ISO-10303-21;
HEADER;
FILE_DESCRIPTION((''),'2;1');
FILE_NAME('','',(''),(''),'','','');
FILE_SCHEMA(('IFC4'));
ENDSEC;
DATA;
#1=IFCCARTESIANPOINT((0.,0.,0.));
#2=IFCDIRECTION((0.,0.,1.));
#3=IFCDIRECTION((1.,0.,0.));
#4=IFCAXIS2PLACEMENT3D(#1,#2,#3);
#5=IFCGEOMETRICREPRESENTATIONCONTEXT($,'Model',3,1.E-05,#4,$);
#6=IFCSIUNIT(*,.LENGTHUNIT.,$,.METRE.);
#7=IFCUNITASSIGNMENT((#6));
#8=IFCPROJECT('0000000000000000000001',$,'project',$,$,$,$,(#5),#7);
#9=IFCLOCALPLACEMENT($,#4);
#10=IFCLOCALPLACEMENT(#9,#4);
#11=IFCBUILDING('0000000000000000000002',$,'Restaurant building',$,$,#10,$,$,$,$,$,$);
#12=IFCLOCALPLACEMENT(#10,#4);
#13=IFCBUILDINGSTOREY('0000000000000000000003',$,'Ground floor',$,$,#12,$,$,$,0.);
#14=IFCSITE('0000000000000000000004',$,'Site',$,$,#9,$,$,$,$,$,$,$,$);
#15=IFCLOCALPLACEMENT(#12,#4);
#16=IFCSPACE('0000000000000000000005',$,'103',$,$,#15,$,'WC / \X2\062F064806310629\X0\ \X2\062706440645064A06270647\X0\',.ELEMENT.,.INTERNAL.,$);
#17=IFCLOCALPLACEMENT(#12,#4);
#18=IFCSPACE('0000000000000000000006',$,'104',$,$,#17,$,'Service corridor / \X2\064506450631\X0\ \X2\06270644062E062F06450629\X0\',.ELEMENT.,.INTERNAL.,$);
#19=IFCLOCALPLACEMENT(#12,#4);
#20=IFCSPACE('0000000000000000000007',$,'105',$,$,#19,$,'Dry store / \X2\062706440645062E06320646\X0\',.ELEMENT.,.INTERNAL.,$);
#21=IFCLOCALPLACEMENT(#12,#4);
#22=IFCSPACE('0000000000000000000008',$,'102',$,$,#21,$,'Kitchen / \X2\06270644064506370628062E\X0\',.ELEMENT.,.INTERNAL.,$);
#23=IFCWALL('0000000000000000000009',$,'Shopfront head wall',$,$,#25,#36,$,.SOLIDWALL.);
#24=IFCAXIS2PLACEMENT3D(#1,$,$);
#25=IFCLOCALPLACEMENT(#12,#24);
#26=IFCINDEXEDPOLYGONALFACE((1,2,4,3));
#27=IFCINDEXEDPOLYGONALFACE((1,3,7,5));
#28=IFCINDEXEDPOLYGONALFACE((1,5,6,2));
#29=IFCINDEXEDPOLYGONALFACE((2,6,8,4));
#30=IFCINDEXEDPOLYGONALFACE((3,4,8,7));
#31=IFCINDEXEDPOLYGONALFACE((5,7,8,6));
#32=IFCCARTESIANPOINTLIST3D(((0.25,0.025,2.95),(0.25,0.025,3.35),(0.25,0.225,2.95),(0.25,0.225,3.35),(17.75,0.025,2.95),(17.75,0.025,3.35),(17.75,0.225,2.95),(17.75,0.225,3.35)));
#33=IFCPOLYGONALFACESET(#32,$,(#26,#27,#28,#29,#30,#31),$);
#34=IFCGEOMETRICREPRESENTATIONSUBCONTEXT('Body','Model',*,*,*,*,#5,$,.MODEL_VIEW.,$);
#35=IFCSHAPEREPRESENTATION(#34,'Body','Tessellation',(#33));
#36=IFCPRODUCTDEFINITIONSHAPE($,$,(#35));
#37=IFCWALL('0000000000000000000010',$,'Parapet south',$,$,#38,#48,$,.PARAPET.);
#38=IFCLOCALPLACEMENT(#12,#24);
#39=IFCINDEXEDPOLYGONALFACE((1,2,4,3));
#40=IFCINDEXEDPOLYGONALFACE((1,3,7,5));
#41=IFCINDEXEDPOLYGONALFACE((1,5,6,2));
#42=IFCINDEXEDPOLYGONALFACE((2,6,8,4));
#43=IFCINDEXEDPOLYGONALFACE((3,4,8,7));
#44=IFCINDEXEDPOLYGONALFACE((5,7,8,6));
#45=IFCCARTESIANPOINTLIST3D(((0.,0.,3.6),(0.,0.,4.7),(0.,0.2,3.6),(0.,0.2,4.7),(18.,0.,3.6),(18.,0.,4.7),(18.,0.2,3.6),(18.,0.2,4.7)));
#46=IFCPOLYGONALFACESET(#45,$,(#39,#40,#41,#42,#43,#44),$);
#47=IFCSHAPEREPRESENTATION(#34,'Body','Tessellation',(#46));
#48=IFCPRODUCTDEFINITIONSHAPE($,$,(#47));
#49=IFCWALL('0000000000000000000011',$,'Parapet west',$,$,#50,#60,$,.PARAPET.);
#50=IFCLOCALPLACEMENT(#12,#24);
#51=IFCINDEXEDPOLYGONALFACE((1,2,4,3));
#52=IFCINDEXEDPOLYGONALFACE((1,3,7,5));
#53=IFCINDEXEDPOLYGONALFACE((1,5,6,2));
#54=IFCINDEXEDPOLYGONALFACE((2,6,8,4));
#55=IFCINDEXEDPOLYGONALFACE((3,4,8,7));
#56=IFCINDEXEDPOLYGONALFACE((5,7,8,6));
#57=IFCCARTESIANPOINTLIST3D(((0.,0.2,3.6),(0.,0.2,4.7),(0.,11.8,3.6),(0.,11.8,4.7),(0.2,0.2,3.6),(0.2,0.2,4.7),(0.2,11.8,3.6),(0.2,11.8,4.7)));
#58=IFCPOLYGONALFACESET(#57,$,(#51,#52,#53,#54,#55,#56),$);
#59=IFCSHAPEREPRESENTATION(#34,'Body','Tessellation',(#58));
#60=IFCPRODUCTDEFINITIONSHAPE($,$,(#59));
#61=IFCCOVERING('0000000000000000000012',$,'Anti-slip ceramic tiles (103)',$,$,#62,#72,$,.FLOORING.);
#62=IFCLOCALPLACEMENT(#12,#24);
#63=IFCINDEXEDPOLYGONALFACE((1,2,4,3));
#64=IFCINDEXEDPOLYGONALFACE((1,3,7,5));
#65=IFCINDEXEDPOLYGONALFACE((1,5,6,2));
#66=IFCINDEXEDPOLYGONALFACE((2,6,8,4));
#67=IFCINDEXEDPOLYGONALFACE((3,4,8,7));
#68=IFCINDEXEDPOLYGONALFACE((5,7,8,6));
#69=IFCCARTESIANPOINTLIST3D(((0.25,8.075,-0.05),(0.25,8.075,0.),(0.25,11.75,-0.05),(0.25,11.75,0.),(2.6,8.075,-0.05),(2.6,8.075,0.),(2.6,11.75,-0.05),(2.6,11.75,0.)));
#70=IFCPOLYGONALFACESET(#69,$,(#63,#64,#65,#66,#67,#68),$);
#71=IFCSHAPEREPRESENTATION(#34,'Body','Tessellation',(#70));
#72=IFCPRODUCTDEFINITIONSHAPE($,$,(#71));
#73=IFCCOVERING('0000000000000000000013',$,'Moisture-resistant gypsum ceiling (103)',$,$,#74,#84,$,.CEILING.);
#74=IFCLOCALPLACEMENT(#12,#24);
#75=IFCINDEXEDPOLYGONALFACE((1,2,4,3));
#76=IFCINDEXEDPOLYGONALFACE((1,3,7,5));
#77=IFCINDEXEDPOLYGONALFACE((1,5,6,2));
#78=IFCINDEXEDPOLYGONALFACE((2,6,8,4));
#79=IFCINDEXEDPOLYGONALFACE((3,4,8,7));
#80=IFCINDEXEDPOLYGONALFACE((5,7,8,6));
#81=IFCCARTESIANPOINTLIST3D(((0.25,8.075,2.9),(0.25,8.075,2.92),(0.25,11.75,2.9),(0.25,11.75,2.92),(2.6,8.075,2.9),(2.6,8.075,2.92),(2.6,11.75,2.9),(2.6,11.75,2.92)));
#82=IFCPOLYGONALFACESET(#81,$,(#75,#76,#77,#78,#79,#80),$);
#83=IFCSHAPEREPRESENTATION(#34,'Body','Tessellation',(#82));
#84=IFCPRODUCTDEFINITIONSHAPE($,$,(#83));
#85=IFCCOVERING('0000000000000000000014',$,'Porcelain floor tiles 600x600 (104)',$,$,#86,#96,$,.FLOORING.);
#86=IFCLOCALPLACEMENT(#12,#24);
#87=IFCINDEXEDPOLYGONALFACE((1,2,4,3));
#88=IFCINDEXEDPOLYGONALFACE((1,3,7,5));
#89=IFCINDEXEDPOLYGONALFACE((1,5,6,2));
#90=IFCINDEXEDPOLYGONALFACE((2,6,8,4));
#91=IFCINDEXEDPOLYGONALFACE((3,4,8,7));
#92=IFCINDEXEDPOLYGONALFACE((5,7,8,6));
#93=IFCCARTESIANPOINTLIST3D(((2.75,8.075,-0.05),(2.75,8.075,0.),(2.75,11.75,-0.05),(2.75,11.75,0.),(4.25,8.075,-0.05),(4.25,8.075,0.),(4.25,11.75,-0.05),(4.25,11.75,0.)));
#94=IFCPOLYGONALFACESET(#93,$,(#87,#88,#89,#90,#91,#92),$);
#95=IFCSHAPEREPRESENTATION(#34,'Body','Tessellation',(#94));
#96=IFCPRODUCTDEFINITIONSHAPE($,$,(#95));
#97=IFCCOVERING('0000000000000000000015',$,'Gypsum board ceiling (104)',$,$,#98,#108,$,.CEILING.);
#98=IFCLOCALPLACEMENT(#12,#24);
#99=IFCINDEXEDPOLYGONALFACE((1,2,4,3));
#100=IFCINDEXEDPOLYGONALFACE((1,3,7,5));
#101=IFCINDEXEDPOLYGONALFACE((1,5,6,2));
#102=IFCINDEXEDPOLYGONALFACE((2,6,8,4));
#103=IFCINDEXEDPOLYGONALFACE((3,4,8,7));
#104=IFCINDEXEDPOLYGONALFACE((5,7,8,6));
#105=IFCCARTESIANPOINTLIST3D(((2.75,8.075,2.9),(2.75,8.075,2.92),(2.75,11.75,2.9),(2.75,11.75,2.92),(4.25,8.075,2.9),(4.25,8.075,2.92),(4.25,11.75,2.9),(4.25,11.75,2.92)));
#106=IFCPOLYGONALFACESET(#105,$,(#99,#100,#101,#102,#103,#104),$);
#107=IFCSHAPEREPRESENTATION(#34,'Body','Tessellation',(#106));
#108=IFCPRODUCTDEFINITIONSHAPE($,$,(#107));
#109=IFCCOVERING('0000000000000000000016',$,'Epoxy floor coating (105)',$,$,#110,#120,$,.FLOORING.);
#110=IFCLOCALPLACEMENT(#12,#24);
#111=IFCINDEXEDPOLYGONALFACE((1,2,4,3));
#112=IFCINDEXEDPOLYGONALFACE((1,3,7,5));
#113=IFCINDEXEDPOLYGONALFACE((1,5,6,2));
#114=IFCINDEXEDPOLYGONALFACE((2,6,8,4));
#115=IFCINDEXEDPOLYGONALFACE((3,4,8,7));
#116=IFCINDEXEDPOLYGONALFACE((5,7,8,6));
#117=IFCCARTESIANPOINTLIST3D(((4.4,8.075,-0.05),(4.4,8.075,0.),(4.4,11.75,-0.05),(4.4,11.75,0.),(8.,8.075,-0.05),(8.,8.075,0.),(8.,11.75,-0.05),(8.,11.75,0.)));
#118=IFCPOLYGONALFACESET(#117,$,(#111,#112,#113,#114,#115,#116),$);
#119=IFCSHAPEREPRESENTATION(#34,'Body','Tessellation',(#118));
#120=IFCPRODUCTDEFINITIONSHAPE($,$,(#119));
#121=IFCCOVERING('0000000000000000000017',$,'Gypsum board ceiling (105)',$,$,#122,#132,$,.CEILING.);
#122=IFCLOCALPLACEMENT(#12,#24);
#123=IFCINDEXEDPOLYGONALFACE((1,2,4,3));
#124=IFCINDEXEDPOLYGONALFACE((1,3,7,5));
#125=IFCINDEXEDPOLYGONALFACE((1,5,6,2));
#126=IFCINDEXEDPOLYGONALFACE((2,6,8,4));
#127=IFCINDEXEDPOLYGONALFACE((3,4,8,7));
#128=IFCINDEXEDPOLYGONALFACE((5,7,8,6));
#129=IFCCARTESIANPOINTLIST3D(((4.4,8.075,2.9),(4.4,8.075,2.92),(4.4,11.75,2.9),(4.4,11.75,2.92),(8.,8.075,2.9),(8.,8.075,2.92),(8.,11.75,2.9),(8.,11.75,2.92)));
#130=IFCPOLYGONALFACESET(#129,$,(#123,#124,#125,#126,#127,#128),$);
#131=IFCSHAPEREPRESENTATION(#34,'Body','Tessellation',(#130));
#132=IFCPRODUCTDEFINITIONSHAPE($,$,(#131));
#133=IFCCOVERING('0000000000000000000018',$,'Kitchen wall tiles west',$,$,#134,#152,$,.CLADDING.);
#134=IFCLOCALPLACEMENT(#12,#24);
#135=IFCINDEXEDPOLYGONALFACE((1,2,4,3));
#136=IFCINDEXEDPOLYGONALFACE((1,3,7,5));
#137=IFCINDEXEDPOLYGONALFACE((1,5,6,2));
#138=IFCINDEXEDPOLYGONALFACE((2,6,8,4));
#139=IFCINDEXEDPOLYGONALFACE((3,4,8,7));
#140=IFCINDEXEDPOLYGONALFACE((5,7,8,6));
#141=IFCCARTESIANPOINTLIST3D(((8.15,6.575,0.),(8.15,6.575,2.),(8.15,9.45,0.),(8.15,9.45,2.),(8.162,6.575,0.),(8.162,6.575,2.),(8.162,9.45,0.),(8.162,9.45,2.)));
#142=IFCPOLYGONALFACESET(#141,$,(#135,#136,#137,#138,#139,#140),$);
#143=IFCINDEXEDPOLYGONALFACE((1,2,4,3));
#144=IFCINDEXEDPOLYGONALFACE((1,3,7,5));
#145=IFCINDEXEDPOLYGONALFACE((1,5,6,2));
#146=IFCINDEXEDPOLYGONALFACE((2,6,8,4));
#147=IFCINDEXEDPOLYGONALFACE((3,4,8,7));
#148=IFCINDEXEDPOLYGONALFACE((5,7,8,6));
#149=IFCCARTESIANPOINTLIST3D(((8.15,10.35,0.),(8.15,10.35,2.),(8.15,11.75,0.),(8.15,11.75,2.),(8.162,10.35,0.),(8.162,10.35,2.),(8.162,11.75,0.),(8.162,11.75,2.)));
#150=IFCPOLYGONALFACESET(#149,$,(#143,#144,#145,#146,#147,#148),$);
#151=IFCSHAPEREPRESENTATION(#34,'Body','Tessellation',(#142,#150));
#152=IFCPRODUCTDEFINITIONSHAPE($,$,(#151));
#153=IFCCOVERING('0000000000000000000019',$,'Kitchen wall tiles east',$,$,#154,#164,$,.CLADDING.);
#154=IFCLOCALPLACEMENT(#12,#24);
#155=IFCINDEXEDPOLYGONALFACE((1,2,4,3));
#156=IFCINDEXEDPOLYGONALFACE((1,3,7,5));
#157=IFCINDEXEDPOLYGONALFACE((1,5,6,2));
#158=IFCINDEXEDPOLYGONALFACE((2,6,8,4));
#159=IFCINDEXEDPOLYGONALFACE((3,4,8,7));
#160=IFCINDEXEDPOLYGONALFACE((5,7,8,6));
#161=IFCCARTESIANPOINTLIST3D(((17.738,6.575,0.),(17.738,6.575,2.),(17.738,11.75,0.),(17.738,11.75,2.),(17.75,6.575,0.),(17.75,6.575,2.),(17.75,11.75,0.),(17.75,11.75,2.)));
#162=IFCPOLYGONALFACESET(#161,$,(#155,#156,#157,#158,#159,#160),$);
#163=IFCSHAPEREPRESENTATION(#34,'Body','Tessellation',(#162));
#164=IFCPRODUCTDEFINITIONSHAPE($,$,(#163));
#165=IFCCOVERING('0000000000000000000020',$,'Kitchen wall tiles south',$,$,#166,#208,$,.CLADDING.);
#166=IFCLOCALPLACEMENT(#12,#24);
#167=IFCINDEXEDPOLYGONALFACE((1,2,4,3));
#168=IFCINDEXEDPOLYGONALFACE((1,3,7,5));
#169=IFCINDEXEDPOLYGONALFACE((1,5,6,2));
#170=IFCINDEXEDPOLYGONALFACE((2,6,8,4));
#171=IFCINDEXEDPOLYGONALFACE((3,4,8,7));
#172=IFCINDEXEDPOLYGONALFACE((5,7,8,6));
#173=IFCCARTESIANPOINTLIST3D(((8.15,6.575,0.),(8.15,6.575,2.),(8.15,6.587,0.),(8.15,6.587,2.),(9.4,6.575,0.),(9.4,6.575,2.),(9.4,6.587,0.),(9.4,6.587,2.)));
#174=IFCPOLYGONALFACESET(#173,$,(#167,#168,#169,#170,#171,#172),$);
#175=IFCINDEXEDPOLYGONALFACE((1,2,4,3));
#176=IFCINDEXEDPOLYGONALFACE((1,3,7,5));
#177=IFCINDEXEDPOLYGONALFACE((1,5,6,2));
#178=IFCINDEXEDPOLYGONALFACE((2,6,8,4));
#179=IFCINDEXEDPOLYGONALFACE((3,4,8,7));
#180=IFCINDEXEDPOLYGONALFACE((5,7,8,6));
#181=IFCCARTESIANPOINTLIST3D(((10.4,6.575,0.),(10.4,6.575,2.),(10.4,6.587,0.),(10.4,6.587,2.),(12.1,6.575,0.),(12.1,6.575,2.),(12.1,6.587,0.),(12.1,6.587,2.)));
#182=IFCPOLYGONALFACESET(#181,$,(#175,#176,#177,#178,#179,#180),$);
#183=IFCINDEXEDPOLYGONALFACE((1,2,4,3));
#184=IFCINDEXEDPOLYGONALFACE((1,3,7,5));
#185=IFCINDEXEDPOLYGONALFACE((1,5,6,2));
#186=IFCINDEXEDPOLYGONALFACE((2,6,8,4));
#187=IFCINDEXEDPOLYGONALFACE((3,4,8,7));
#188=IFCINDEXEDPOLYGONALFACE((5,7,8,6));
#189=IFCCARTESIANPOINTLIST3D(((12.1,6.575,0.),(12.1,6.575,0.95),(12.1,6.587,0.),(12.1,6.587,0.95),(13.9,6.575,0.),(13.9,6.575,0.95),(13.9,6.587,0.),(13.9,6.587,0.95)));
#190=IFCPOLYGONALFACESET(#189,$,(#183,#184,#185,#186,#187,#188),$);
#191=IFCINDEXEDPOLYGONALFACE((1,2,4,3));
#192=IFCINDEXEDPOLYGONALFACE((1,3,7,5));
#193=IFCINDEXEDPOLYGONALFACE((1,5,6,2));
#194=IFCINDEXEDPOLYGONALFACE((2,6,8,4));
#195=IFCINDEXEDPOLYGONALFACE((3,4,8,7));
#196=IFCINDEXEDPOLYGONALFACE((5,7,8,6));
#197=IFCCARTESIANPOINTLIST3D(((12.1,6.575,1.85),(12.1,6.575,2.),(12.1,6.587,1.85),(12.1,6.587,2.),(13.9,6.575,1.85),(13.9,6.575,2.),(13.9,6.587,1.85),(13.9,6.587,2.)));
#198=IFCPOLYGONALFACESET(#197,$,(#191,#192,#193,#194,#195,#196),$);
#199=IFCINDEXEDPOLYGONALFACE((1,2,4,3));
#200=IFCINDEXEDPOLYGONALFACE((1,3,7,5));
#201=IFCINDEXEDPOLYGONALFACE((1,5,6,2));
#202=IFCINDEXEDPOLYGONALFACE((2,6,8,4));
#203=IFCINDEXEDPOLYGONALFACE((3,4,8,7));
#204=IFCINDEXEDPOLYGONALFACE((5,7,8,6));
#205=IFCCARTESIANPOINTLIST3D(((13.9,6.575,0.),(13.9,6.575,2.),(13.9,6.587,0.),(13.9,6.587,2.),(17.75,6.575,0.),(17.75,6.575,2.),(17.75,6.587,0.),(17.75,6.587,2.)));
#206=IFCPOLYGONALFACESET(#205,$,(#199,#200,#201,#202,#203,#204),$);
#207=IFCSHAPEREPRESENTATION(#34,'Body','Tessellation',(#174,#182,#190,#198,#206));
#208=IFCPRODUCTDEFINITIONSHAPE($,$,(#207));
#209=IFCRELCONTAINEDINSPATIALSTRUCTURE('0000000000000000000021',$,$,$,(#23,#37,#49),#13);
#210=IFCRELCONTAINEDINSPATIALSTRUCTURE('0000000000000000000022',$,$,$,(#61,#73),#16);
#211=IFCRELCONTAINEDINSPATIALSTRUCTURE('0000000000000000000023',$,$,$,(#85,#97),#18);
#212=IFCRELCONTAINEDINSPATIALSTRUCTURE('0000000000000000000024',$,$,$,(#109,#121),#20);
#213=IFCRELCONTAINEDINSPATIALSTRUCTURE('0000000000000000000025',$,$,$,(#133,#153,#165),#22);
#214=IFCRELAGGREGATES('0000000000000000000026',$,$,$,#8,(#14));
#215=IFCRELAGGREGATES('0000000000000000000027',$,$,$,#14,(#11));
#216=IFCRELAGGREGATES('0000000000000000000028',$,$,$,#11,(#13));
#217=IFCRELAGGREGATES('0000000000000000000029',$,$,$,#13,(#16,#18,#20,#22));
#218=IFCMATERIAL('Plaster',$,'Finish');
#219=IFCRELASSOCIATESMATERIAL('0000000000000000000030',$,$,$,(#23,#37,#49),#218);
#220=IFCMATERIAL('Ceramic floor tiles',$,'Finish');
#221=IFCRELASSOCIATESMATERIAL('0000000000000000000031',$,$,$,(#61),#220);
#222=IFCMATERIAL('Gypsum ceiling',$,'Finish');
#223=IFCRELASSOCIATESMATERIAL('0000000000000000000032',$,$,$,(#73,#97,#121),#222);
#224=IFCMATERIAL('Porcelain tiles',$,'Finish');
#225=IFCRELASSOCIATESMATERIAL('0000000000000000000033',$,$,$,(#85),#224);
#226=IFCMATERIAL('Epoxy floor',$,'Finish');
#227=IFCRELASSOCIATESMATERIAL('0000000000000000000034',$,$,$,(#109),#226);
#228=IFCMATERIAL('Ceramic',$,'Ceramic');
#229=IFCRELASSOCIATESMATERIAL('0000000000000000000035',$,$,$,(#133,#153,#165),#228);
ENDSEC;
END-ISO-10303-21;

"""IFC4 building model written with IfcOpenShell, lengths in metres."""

from ifc_helpers import new_model, si_unit, frame, origin, origin_with_axes, origin_2d, place, context, subcontext, project, spatial, polyline, rectangle, outline, extrude, material, element, save


model = new_model("IFC4")

# Units and contexts
model_context = context("Model", 3, precision=1e-05, world=origin_with_axes())
body_context = subcontext(model_context, "Body", "Model", "MODEL_VIEW")
ifc_project = project(units=[si_unit("LENGTHUNIT", "METRE")], contexts=[model_context])

# Site, building, storey
site_placement = place(None, origin_with_axes())
site = spatial("IfcSite", under=ifc_project, at=site_placement, Name="Site")
building_placement = place(site_placement, origin_with_axes())
building = spatial("IfcBuilding", under=site, at=building_placement, Name="Restaurant building")
storey_placement = place(building_placement, origin_with_axes())
storey = spatial("IfcBuildingStorey", under=building, at=storey_placement, Name="Ground floor", Elevation=0.0)

# Shared definitions
ifc_material_1 = material(Name="Plaster", Category="Finish")

# Walls
wall_1_placement = place(storey_placement, frame((0.25, 0.125, 0.0)))
element("IfcWall", 1, at=wall_1_placement, inside=storey, material=ifc_material_1, Name="Shopfront head wall", PredefinedType="SOLIDWALL", context=body_context, shape_type="SweptSolid", body=[
    extrude(rectangle(XDim=17.5, YDim=0.2, at=origin_2d()), frame((8.75, 0.0, 2.95)), (0.0, 0.0, 1.0), 0.4),
])
wall_2_placement = place(storey_placement, frame((0.0, 0.1, 0.0)))
element("IfcWall", 2, at=wall_2_placement, inside=storey, material=ifc_material_1, Name="Parapet south", PredefinedType="PARAPET", context=body_context, shape_type="SweptSolid", body=[
    extrude(rectangle(XDim=18.0, YDim=0.2, at=origin_2d()), frame((9.0, 0.0, 3.6)), (0.0, 0.0, 1.0), 1.1),
])
wall_3_placement = place(storey_placement, frame((0.1, 0.2, 0.0), z_axis=(0.0, 0.0, 1.0), x_axis=(0.0, 1.0, 0.0)))
element("IfcWall", 3, at=wall_3_placement, inside=storey, material=ifc_material_1, Name="Parapet west", PredefinedType="PARAPET", context=body_context, shape_type="SweptSolid", body=[
    extrude(rectangle(XDim=11.6, YDim=0.2, at=origin_2d()), frame((5.8, 0.0, 3.6)), (0.0, 0.0, 1.0), 1.1),
])

# Shared definitions
space_1_placement = place(storey_placement, origin_with_axes())
space_1 = spatial("IfcSpace", under=storey, at=space_1_placement, Name="103", LongName="WC / دورة المياه", CompositionType="ELEMENT", PredefinedType="INTERNAL")

# Coverings
ifc_material_2 = material(Name="Ceramic floor tiles", Category="Finish")
covering_1_placement = place(storey_placement, origin())
element("IfcCovering", 4, at=covering_1_placement, inside=space_1, material=ifc_material_2, Name="Anti-slip ceramic tiles (103)", PredefinedType="FLOORING", context=body_context, shape_type="SweptSolid", body=[
    extrude(outline(polyline([(0.25, 8.075), (2.6, 8.075), (2.6, 11.75), (0.25, 11.75), (0.25, 8.075)])), frame((0.0, 0.0, -0.05)), (0.0, 0.0, 1.0), 0.05),
])
ifc_material_3 = material(Name="Gypsum ceiling", Category="Finish")
covering_2_placement = place(storey_placement, origin())
element("IfcCovering", 5, at=covering_2_placement, inside=space_1, material=ifc_material_3, Name="Moisture-resistant gypsum ceiling (103)", PredefinedType="CEILING", context=body_context, shape_type="SweptSolid", body=[
    extrude(outline(polyline([(0.25, 8.075), (2.6, 8.075), (2.6, 11.75), (0.25, 11.75), (0.25, 8.075)])), frame((0.0, 0.0, 2.9)), (0.0, 0.0, 1.0), 0.02),
])

# Shared definitions
space_2_placement = place(storey_placement, origin_with_axes())
space_2 = spatial("IfcSpace", under=storey, at=space_2_placement, Name="104", LongName="Service corridor / ممر الخدمة", CompositionType="ELEMENT", PredefinedType="INTERNAL")

# Coverings
ifc_material_4 = material(Name="Porcelain tiles", Category="Finish")
covering_3_placement = place(storey_placement, origin())
element("IfcCovering", 6, at=covering_3_placement, inside=space_2, material=ifc_material_4, Name="Porcelain floor tiles 600x600 (104)", PredefinedType="FLOORING", context=body_context, shape_type="SweptSolid", body=[
    extrude(outline(polyline([(2.75, 8.075), (4.25, 8.075), (4.25, 11.75), (2.75, 11.75), (2.75, 8.075)])), frame((0.0, 0.0, -0.05)), (0.0, 0.0, 1.0), 0.05),
])
covering_4_placement = place(storey_placement, origin())
element("IfcCovering", 7, at=covering_4_placement, inside=space_2, material=ifc_material_3, Name="Gypsum board ceiling (104)", PredefinedType="CEILING", context=body_context, shape_type="SweptSolid", body=[
    extrude(outline(polyline([(2.75, 8.075), (4.25, 8.075), (4.25, 11.75), (2.75, 11.75), (2.75, 8.075)])), frame((0.0, 0.0, 2.9)), (0.0, 0.0, 1.0), 0.02),
])

# Shared definitions
space_3_placement = place(storey_placement, origin_with_axes())
space_3 = spatial("IfcSpace", under=storey, at=space_3_placement, Name="105", LongName="Dry store / المخزن", CompositionType="ELEMENT", PredefinedType="INTERNAL")

# Coverings
ifc_material_5 = material(Name="Epoxy floor", Category="Finish")
covering_5_placement = place(storey_placement, origin())
element("IfcCovering", 8, at=covering_5_placement, inside=space_3, material=ifc_material_5, Name="Epoxy floor coating (105)", PredefinedType="FLOORING", context=body_context, shape_type="SweptSolid", body=[
    extrude(outline(polyline([(4.4, 8.075), (8.0, 8.075), (8.0, 11.75), (4.4, 11.75), (4.4, 8.075)])), frame((0.0, 0.0, -0.05)), (0.0, 0.0, 1.0), 0.05),
])
covering_6_placement = place(storey_placement, origin())
element("IfcCovering", 9, at=covering_6_placement, inside=space_3, material=ifc_material_3, Name="Gypsum board ceiling (105)", PredefinedType="CEILING", context=body_context, shape_type="SweptSolid", body=[
    extrude(outline(polyline([(4.4, 8.075), (8.0, 8.075), (8.0, 11.75), (4.4, 11.75), (4.4, 8.075)])), frame((0.0, 0.0, 2.9)), (0.0, 0.0, 1.0), 0.02),
])

# Shared definitions
space_4_placement = place(storey_placement, origin_with_axes())
space_4 = spatial("IfcSpace", under=storey, at=space_4_placement, Name="102", LongName="Kitchen / المطبخ", CompositionType="ELEMENT", PredefinedType="INTERNAL")

# Coverings
ifc_material_6 = material(Name="Ceramic", Category="Ceramic")
covering_7_placement = place(storey_placement, origin())
element("IfcCovering", 10, at=covering_7_placement, inside=space_4, material=ifc_material_6, Name="Kitchen wall tiles west", PredefinedType="CLADDING", context=body_context, shape_type="SweptSolid", body=[
    extrude(rectangle(XDim=0.012, YDim=2.875, at=origin_2d()), frame((8.156, 8.0125, 0.0)), (0.0, 0.0, 1.0), 2.0),
    extrude(rectangle(XDim=0.012, YDim=1.4, at=origin_2d()), frame((8.156, 11.05, 0.0)), (0.0, 0.0, 1.0), 2.0),
])
covering_8_placement = place(storey_placement, origin())
element("IfcCovering", 11, at=covering_8_placement, inside=space_4, material=ifc_material_6, Name="Kitchen wall tiles east", PredefinedType="CLADDING", context=body_context, shape_type="SweptSolid", body=[
    extrude(rectangle(XDim=0.012, YDim=5.175, at=origin_2d()), frame((17.744, 9.1625, 0.0)), (0.0, 0.0, 1.0), 2.0),
])
covering_9_placement = place(storey_placement, origin())
element("IfcCovering", 12, at=covering_9_placement, inside=space_4, material=ifc_material_6, Name="Kitchen wall tiles south", PredefinedType="CLADDING", context=body_context, shape_type="SweptSolid", body=[
    extrude(rectangle(XDim=1.25, YDim=0.012, at=origin_2d()), frame((8.775, 6.581, 0.0)), (0.0, 0.0, 1.0), 2.0),
    extrude(rectangle(XDim=1.7, YDim=0.012, at=origin_2d()), frame((11.25, 6.581, 0.0)), (0.0, 0.0, 1.0), 2.0),
    extrude(rectangle(XDim=1.8, YDim=0.012, at=origin_2d()), frame((13.0, 6.581, 0.0)), (0.0, 0.0, 1.0), 0.95),
    extrude(rectangle(XDim=1.8, YDim=0.012, at=origin_2d()), frame((13.0, 6.581, 1.85)), (0.0, 0.0, 1.0), 0.15),
    extrude(rectangle(XDim=3.85, YDim=0.012, at=origin_2d()), frame((15.825, 6.581, 0.0)), (0.0, 0.0, 1.0), 2.0),
])

save(model, "model.ifc")
